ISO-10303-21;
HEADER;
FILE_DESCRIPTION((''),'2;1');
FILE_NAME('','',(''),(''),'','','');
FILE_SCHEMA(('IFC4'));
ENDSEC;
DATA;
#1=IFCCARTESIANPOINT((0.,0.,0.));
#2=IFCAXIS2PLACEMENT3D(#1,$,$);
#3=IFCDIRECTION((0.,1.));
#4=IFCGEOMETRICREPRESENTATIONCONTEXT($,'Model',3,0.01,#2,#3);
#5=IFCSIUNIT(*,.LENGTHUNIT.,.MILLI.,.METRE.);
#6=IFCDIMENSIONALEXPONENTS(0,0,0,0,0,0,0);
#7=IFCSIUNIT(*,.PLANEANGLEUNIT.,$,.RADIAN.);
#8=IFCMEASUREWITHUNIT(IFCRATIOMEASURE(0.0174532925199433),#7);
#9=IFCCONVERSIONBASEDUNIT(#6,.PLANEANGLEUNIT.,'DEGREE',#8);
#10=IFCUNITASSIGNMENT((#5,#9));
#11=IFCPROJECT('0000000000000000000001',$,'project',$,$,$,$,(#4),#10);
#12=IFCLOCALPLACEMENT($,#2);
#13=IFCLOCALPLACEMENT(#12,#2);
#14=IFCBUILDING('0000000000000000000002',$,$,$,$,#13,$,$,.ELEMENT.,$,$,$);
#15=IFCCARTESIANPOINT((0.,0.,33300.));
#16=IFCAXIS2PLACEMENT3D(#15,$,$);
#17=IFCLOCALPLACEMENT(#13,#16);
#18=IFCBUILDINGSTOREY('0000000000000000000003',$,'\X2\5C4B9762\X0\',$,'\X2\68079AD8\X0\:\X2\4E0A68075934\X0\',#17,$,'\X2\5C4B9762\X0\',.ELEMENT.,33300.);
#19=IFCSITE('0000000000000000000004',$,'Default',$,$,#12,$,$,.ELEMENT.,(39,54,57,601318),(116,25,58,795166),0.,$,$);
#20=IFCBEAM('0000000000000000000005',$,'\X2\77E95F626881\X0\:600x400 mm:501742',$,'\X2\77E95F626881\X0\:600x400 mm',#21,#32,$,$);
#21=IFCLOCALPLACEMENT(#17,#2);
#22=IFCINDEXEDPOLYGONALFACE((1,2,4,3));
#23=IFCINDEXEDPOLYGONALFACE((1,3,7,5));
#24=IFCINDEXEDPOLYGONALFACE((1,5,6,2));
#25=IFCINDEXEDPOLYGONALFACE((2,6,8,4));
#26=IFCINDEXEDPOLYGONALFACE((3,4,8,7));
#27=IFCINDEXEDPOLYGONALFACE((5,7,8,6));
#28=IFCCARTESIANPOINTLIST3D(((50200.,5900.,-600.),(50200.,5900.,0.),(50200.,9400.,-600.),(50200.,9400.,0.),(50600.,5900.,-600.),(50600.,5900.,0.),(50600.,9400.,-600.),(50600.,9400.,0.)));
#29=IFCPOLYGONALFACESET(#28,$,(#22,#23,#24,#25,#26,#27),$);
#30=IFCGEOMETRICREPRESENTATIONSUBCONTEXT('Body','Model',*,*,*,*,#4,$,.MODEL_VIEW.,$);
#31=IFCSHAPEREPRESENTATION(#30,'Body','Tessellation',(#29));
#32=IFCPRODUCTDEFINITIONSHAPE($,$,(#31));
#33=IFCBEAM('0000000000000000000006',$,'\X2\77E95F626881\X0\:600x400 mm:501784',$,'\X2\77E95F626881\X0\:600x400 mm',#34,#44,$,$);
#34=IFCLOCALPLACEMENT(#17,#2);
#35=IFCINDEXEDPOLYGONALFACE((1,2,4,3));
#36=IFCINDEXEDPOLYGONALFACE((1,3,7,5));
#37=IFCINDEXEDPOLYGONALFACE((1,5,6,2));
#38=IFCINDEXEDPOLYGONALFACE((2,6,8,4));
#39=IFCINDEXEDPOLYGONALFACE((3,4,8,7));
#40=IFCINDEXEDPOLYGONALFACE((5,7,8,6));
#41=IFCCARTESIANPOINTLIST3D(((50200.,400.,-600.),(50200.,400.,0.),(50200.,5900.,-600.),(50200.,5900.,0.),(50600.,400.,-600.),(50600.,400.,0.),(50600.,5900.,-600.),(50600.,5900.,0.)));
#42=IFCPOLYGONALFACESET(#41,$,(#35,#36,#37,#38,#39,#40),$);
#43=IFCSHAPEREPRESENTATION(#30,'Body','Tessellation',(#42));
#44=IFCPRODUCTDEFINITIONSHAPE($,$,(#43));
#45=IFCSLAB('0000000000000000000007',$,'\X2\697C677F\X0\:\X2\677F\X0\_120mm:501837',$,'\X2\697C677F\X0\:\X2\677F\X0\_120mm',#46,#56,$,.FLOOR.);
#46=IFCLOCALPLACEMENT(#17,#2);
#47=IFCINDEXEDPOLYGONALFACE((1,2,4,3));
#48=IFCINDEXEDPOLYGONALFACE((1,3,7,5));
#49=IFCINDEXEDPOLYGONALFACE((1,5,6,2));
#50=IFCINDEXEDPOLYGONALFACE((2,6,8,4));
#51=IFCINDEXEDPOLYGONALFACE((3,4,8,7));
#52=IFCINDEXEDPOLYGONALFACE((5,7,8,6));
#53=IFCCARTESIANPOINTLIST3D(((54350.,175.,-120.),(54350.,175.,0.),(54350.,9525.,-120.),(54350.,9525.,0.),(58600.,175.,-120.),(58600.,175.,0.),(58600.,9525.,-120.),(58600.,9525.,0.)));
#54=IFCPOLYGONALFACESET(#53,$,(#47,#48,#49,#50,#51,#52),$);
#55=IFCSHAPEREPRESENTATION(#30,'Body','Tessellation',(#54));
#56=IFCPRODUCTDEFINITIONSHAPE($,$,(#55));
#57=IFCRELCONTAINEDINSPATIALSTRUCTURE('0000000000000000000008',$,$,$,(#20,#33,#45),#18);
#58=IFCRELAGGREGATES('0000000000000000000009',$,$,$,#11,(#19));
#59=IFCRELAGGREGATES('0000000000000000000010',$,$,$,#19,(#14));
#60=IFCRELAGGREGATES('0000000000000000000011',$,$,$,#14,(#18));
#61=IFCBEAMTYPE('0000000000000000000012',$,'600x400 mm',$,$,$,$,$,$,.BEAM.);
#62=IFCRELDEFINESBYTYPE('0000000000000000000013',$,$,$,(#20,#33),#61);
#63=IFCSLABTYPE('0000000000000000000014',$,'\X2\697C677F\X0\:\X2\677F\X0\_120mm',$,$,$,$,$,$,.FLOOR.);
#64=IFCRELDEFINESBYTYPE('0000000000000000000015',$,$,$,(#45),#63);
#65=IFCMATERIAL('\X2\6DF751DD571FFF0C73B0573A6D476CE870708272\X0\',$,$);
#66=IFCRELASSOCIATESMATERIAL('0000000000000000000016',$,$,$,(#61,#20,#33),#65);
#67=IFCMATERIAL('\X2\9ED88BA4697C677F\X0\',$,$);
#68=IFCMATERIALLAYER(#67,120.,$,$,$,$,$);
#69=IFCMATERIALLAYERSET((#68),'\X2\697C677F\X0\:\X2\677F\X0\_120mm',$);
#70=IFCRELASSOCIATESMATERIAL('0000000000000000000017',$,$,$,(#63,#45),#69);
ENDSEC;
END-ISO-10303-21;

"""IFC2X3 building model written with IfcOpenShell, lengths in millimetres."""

from ifc_helpers import new_model, entity, si_unit, converted_unit, direction, frame, frame_2d, origin, place, context, subcontext, project, spatial, rectangle, extrude, material, layer, layer_set, layer_usage, type_object, element, save


model = new_model("IFC2X3")

# Units and contexts
model_context = context("Model", 3, precision=0.01, world=origin(), true_north=direction((0.0, 1.0)))
body_context = subcontext(model_context, "Body", "Model", "MODEL_VIEW")
ifc_project = project(units=[si_unit("LENGTHUNIT", "METRE", prefix="MILLI"), converted_unit("PLANEANGLEUNIT", "DEGREE", entity("IfcRatioMeasure", 0.0174532925199433), si_unit("PLANEANGLEUNIT", "RADIAN"), dimensions=[0, 0, 0, 0, 0, 0, 0])], contexts=[model_context])

# Site, building, storey
site_placement = place(None, origin())
site = spatial("IfcSite", under=ifc_project, at=site_placement, Name="Default", CompositionType="ELEMENT", RefLatitude=(39, 54, 57, 601318), RefLongitude=(116, 25, 58, 795166), RefElevation=0.0)
building_placement = place(site_placement, origin())
building = spatial("IfcBuilding", under=site, at=building_placement, CompositionType="ELEMENT")
storey_placement = place(building_placement, frame((0.0, 0.0, 33300.0)))
storey = spatial("IfcBuildingStorey", under=building, at=storey_placement, Name="屋面", ObjectType="标高:上标头", LongName="屋面", CompositionType="ELEMENT", Elevation=33300.0)

# Beams
ifc_material_1 = material(Name="混凝土，现场浇注灰色")
beam_type_1 = type_object("IfcBeamType", Name="600x400 mm", PredefinedType="BEAM", material=ifc_material_1)
beam_1_placement = place(storey_placement, frame((50400.0, 5900.0, 0.0), z_axis=(0.0, 0.0, 1.0), x_axis=(0.0, 1.0, 0.0)))
element("IfcBeam", 1, at=beam_1_placement, inside=storey, type_object=beam_type_1, material=ifc_material_1, Name="矩形梁:600x400 mm:501742", ObjectType="矩形梁:600x400 mm", context=body_context, shape_type="SweptSolid", body=[
    extrude(rectangle(XDim=600.0, YDim=400.0, at=frame_2d((0.0, 0.0), x_axis=(1.0, 0.0))), frame((0.0, 0.0, -300.0), z_axis=(1.0, 0.0, 0.0), x_axis=(0.0, 0.0, -1.0)), (0.0, 0.0, 1.0), 3500.0),
])
beam_2_placement = place(storey_placement, frame((50400.0, 200.0, 0.0), z_axis=(0.0, 0.0, 1.0), x_axis=(0.0, 1.0, 0.0)))
element("IfcBeam", 2, at=beam_2_placement, inside=storey, type_object=beam_type_1, material=ifc_material_1, Name="矩形梁:600x400 mm:501784", ObjectType="矩形梁:600x400 mm", context=body_context, shape_type="SweptSolid", body=[
    extrude(rectangle(XDim=600.0, YDim=400.0, at=frame_2d((0.0, 0.0), x_axis=(1.0, 0.0))), frame((200.0, 0.0, -300.0), z_axis=(1.0, 0.0, 0.0), x_axis=(0.0, 0.0, -1.0)), (0.0, 0.0, 1.0), 5500.0),
])

# Slab
ifc_material_2 = material(Name="默认楼板")
ifc_layer = layer(ifc_material_2, 120.0)
ifc_layer_set = layer_set([ifc_layer], Name="楼板:板_120mm")
ifc_layer_usage_1 = layer_usage(ifc_layer_set, "AXIS3", "POSITIVE", 0.0)
slab_type_1 = type_object("IfcSlabType", Name="楼板:板_120mm", PredefinedType="FLOOR", material=ifc_layer_set)
slab_1_placement = place(storey_placement, origin())
element("IfcSlab", 3, at=slab_1_placement, inside=storey, type_object=slab_type_1, material=ifc_layer_usage_1, Name="楼板:板_120mm:501837", ObjectType="楼板:板_120mm", PredefinedType="FLOOR", context=body_context, shape_type="SweptSolid", body=[
    extrude(rectangle(XDim=9350.0, YDim=4250.0, at=frame_2d((0.0, 0.0), x_axis=(1.0, 0.0))), frame((56475.0, 4850.0, 0.0), z_axis=(0.0, 0.0, -1.0), x_axis=(0.0, 1.0, 0.0)), (0.0, 0.0, 1.0), 120.0),
])

save(model, "model.ifc")
